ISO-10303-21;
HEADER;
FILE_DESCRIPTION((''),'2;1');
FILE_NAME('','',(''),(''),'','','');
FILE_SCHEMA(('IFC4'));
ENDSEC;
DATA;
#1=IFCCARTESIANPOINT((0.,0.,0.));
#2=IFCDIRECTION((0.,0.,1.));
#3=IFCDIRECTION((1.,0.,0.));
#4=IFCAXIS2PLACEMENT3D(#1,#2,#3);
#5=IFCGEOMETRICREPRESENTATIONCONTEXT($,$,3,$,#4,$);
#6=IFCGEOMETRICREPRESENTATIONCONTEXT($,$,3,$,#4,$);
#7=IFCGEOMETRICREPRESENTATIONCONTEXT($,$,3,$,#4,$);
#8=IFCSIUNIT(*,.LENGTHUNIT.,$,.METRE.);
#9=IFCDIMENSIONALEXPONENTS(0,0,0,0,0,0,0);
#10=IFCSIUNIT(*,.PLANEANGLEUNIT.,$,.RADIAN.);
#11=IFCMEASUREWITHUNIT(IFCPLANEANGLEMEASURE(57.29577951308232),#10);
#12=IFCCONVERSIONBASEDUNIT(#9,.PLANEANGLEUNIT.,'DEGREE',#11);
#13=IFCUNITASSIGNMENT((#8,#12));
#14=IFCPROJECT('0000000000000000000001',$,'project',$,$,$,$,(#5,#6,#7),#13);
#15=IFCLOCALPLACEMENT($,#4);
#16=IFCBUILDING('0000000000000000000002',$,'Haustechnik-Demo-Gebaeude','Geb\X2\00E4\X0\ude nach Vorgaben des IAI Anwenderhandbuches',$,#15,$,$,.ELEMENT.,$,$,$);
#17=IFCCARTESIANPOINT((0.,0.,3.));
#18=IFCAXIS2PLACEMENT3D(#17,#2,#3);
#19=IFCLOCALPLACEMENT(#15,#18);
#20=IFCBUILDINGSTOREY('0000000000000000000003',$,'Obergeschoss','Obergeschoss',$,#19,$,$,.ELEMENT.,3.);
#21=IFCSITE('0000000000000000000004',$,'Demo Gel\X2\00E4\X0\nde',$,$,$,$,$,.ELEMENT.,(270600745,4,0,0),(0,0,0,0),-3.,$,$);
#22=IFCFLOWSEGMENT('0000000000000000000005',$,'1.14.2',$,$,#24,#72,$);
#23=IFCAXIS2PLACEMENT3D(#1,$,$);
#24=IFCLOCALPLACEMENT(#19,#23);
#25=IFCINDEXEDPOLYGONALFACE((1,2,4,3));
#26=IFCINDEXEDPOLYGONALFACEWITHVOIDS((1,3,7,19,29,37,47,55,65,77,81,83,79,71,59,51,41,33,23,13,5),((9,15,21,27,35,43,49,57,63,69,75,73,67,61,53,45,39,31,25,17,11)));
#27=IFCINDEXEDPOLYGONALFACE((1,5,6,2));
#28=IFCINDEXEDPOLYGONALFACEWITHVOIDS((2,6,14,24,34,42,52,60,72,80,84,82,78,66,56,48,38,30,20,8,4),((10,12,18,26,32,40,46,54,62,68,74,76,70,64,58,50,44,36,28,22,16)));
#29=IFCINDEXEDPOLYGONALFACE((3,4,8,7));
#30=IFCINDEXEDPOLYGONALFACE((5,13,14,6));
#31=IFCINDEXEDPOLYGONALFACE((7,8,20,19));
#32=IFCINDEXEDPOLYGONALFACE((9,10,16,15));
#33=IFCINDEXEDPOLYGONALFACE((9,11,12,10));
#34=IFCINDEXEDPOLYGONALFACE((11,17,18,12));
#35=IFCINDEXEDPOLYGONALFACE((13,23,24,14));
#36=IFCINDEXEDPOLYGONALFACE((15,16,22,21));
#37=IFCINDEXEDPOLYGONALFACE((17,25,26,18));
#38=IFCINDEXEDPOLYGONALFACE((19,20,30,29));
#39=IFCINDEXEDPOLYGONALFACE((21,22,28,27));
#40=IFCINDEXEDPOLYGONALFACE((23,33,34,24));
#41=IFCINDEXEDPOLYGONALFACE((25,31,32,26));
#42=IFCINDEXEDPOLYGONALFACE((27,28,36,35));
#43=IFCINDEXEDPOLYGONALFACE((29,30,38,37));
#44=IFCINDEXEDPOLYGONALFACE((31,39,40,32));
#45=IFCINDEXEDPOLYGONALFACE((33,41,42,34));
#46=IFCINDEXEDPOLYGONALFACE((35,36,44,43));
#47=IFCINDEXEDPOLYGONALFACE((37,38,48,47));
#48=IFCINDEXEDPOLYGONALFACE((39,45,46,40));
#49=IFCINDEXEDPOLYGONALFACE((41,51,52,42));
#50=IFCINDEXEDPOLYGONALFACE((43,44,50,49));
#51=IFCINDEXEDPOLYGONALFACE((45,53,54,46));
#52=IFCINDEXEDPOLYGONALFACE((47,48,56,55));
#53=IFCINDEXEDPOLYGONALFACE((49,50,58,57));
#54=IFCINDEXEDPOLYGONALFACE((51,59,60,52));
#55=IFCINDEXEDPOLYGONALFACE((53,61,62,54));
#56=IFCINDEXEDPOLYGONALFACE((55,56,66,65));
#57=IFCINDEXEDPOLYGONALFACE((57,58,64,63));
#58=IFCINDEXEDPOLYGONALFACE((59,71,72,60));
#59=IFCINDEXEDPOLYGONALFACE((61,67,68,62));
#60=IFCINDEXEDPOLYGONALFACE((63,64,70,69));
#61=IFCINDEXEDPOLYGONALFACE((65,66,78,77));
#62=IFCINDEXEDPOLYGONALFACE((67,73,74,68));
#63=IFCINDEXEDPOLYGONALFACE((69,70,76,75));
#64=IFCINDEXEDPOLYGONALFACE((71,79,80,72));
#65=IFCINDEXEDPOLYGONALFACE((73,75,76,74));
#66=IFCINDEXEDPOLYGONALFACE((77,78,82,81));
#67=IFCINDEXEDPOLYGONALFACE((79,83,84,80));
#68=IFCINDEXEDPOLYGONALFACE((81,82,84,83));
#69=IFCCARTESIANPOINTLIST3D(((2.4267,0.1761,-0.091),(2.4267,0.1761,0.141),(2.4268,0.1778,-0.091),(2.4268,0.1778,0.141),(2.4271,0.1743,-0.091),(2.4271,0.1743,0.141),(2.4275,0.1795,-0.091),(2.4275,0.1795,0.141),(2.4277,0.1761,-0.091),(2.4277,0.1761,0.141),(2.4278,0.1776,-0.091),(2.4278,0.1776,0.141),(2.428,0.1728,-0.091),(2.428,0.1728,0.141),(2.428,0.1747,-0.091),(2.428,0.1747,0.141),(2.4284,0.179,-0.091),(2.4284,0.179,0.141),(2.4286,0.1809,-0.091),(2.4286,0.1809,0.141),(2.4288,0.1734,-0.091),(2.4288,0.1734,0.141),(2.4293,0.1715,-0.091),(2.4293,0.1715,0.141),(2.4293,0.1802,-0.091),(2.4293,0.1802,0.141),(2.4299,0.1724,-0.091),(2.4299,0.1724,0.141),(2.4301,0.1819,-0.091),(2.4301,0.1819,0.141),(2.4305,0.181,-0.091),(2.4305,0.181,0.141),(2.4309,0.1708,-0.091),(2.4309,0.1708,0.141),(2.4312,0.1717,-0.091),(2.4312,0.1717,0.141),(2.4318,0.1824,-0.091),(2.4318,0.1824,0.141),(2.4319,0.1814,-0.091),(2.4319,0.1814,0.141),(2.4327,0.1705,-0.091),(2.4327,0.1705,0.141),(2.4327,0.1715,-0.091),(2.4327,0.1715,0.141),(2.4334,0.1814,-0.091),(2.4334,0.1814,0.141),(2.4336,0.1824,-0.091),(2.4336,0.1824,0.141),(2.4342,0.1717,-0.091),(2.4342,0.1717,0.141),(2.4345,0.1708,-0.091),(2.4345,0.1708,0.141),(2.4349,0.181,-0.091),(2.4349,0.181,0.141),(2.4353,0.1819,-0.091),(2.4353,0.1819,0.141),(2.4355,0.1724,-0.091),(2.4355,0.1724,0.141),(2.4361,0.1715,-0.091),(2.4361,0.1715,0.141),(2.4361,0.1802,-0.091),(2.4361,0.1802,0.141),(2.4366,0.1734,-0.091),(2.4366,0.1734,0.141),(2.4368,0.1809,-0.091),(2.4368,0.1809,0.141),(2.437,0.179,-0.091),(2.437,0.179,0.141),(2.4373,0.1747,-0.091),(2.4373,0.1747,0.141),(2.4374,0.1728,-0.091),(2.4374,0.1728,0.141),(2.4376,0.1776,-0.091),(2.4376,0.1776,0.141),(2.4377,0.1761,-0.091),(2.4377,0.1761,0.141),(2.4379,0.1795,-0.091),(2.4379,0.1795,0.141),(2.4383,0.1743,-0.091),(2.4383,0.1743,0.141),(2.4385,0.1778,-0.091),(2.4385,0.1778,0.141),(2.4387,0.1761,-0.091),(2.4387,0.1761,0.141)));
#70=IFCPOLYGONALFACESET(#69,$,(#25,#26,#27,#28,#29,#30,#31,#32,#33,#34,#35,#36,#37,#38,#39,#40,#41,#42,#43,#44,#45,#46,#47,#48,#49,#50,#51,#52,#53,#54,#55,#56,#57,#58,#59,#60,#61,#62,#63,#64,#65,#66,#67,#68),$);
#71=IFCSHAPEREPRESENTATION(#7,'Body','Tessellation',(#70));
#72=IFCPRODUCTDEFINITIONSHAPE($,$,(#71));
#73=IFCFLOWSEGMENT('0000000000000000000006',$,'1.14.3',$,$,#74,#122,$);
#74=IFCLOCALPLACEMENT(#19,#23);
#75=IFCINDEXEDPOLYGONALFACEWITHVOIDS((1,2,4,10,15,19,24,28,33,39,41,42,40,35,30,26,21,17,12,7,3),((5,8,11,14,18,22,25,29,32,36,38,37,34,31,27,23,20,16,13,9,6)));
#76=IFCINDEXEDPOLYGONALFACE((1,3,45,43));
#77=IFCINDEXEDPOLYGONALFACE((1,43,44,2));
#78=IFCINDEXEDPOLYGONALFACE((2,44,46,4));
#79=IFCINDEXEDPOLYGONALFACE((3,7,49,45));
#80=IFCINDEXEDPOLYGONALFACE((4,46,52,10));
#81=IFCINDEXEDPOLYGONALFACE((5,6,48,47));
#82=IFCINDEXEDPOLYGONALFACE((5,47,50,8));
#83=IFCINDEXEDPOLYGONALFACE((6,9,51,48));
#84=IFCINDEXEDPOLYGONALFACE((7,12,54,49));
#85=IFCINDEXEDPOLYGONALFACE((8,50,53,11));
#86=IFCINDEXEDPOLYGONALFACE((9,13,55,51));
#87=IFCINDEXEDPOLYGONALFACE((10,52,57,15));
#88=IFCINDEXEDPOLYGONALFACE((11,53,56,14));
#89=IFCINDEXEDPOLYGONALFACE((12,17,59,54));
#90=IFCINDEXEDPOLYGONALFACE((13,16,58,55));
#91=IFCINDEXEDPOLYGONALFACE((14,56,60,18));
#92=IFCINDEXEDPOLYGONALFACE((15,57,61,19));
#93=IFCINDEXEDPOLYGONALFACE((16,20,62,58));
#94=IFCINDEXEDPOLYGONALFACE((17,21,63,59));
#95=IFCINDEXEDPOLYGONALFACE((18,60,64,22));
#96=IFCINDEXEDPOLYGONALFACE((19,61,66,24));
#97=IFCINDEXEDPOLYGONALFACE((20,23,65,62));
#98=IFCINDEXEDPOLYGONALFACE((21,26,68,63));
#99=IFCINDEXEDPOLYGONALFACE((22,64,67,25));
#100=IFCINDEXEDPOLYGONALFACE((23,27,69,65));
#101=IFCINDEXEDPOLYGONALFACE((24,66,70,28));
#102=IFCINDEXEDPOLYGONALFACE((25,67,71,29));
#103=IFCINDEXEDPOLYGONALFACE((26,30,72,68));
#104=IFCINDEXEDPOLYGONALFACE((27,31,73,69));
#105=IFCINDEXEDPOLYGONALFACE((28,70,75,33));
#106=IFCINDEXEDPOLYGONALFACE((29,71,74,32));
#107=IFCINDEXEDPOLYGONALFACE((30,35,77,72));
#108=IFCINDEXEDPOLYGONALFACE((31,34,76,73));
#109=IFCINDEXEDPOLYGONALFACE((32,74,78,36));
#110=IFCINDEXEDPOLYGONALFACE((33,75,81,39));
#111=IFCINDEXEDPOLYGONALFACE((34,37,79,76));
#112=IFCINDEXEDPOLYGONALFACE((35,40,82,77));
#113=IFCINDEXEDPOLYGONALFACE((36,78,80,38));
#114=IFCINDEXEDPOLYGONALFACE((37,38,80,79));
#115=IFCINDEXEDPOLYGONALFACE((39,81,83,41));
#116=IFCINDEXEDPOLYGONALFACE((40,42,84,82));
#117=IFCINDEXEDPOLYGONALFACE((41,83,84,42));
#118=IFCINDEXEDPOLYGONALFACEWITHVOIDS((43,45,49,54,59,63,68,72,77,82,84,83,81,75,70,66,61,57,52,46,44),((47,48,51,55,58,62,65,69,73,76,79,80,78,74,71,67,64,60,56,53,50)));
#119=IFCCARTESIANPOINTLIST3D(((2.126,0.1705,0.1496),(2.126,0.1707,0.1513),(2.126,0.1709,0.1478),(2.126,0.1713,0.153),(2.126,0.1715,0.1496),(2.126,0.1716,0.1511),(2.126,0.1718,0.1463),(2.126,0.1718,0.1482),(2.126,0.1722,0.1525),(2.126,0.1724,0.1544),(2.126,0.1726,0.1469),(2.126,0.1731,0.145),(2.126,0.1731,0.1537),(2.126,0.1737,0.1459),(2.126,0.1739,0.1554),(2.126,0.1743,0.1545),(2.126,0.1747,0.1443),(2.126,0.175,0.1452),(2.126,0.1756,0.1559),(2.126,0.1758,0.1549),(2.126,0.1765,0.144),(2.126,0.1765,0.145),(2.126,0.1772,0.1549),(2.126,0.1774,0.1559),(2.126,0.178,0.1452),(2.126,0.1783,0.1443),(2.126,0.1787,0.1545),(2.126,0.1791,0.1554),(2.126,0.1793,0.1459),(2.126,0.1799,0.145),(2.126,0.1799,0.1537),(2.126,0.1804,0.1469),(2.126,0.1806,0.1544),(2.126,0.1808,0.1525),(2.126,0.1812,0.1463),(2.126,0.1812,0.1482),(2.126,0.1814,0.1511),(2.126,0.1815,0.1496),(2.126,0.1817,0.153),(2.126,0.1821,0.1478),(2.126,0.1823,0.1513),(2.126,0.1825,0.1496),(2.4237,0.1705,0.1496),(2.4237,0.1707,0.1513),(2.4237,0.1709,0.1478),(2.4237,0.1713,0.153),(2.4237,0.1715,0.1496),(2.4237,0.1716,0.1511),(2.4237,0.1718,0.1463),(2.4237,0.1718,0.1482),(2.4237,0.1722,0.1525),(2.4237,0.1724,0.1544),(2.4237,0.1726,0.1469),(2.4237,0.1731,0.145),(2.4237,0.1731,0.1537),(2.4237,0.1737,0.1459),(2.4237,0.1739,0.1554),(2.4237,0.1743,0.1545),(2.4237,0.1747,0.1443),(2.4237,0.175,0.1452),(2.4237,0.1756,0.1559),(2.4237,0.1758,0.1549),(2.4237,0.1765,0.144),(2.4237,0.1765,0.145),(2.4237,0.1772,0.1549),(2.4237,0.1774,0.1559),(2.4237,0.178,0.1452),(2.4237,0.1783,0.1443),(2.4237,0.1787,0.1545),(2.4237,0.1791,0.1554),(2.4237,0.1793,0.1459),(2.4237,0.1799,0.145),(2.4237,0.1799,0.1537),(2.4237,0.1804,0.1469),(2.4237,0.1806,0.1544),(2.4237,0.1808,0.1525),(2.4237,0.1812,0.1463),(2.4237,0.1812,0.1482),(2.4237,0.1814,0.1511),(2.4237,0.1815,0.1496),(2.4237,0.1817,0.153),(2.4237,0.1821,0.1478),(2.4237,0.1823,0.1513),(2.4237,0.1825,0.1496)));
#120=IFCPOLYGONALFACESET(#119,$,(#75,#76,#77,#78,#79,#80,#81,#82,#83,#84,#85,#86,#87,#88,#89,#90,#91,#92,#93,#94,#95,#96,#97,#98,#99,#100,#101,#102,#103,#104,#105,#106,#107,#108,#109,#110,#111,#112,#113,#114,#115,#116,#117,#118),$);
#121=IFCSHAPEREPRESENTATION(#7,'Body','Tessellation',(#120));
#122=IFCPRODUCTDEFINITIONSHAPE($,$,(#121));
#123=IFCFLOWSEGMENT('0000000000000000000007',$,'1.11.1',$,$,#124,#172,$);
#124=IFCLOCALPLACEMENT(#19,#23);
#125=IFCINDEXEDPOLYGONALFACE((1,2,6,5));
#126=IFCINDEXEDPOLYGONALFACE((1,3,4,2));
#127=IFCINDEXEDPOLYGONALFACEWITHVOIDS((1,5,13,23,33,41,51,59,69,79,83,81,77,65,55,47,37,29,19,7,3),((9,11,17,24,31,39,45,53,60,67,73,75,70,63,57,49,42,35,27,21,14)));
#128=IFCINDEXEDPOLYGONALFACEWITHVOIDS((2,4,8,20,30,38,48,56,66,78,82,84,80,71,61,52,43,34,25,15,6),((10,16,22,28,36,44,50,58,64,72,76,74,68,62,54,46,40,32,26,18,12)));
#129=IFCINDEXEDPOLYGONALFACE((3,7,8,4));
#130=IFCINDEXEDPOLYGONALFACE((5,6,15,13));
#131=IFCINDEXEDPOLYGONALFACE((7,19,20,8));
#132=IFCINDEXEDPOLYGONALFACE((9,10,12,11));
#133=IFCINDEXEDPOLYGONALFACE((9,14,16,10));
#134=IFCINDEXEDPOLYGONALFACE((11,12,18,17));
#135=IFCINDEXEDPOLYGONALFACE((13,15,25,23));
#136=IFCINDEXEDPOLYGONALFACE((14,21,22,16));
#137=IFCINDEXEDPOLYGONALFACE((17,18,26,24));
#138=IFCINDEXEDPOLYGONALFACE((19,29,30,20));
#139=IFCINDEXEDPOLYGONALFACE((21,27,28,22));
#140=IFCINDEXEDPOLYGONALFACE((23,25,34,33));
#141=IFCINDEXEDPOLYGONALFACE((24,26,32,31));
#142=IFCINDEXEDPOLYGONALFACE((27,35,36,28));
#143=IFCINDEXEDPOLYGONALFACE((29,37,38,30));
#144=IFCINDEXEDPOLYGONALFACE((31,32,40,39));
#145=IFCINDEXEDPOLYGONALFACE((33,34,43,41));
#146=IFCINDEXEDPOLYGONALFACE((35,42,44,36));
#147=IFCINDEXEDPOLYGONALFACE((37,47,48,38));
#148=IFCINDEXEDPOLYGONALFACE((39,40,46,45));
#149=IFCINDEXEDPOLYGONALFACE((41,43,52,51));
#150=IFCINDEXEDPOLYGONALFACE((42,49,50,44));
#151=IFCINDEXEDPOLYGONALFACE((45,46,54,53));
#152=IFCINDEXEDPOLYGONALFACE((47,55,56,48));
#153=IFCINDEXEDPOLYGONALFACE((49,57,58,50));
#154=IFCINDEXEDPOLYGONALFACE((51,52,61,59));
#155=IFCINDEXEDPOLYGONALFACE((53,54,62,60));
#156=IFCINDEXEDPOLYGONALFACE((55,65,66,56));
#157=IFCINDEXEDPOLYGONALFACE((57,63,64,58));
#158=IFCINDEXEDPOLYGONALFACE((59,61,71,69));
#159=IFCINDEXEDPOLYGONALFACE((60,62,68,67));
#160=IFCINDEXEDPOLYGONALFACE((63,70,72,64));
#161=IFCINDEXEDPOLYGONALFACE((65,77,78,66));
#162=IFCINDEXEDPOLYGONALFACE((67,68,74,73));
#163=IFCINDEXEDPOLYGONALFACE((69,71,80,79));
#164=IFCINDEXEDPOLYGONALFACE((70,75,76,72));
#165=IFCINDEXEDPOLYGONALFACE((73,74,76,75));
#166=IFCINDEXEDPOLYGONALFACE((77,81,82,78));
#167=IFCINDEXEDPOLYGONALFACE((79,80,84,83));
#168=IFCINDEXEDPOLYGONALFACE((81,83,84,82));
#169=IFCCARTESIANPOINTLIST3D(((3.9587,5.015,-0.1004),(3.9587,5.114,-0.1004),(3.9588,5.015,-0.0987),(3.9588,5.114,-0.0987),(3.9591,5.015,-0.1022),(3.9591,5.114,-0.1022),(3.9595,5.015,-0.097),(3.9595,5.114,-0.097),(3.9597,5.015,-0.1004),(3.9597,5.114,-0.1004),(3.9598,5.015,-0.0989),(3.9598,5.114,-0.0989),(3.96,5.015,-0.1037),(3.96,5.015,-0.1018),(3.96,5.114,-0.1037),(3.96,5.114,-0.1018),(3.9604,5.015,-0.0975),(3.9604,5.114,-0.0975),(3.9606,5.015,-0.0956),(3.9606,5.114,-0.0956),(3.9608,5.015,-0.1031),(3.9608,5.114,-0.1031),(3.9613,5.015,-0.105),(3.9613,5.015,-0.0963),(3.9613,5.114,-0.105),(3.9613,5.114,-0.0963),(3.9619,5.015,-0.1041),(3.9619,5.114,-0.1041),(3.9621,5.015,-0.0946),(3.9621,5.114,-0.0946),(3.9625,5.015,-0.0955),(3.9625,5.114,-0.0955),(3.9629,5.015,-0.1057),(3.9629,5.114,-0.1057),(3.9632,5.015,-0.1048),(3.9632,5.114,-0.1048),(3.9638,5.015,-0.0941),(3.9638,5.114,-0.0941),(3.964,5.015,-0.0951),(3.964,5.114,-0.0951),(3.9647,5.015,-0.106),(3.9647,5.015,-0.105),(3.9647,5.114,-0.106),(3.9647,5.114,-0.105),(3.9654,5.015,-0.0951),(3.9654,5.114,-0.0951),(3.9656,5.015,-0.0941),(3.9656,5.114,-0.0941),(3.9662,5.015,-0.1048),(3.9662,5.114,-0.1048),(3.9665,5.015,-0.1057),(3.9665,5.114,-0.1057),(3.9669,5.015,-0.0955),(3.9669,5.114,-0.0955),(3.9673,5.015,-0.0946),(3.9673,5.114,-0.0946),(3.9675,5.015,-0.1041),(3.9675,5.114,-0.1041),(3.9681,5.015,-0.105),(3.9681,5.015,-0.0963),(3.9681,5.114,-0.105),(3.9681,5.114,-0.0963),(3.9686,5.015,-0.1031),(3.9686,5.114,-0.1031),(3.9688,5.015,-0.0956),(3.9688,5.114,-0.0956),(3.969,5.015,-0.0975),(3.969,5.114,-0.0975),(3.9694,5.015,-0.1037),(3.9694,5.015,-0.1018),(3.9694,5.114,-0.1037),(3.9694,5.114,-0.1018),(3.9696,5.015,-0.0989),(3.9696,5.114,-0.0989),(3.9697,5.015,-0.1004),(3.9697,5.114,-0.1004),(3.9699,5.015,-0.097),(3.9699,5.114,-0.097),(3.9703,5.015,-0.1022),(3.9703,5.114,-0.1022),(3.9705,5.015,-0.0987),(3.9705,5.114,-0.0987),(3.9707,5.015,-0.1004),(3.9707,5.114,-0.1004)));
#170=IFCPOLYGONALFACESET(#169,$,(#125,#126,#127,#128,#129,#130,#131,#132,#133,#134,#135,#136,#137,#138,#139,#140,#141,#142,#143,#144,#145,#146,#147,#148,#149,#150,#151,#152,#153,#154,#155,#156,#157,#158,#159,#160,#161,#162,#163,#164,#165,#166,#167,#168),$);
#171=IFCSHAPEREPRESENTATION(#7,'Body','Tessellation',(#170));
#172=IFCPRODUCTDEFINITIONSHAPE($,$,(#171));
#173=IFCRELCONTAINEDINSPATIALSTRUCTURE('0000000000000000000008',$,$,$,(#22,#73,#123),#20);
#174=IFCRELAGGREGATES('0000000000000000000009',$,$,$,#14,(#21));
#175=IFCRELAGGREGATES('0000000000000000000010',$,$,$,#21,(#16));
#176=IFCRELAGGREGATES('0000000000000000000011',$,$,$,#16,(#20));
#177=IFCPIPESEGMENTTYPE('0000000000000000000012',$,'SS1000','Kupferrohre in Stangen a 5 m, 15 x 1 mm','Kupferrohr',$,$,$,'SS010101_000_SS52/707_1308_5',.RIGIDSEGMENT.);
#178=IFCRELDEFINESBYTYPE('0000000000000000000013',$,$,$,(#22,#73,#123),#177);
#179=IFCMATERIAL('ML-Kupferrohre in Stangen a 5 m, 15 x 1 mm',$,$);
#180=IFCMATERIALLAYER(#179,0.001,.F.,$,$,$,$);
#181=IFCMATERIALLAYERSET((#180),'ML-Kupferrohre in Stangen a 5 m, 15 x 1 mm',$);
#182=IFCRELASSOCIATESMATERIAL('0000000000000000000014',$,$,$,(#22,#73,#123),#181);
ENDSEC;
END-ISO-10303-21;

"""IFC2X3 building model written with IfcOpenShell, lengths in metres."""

from ifc_helpers import new_model, entity, si_unit, converted_unit, frame, origin_with_axes, origin_2d_with_axis, place, context, project, spatial, hollow_circle, extrude, material, layer, layer_set, layer_usage, type_object, element, save


model = new_model("IFC2X3")

# Units and contexts
context_of_model_1 = context(None, 3, world=origin_with_axes())
context_of_model_2 = context(None, 3, world=origin_with_axes())
context_of_model_3 = context(None, 3, world=origin_with_axes())
ifc_project = project(units=[si_unit("LENGTHUNIT", "METRE"), converted_unit("PLANEANGLEUNIT", "DEGREE", entity("IfcPlaneAngleMeasure", 57.29577951308232), si_unit("PLANEANGLEUNIT", "RADIAN"), dimensions=[0, 0, 0, 0, 0, 0, 0])], contexts=[context_of_model_1, context_of_model_2, context_of_model_3])

# Site, building, storey
site = spatial("IfcSite", under=ifc_project, Name="Demo Gelände", CompositionType="ELEMENT", RefLatitude=(270600745, 4, 0, 0), RefLongitude=(0, 0, 0, 0), RefElevation=-3.0)
building_placement = place(None, origin_with_axes())
building = spatial("IfcBuilding", under=site, at=building_placement, Name="Haustechnik-Demo-Gebaeude", Description="Gebäude nach Vorgaben des IAI Anwenderhandbuches", CompositionType="ELEMENT")
storey_placement = place(building_placement, frame((0.0, 0.0, 3.0), z_axis=(0.0, 0.0, 1.0), x_axis=(1.0, 0.0, 0.0)))
storey = spatial("IfcBuildingStorey", under=building, at=storey_placement, Name="Obergeschoss", Description="Obergeschoss", CompositionType="ELEMENT", Elevation=3.0)

# Flow segments
ifc_material = material(Name="ML-Kupferrohre in Stangen a 5 m, 15 x 1 mm")
ifc_layer = layer(ifc_material, 0.001, ventilated=False)
ifc_layer_set = layer_set([ifc_layer], Name="ML-Kupferrohre in Stangen a 5 m, 15 x 1 mm")
ifc_layer_usage = layer_usage(ifc_layer_set, "AXIS2", "POSITIVE", 0.0)
pipe_segment_type_1 = type_object("IfcPipeSegmentType", Name="SS1000", Description="Kupferrohre in Stangen a 5 m, 15 x 1 mm", ApplicableOccurrence="Kupferrohr", ElementType="SS010101_000_SS52/707_1308_5", PredefinedType="RIGIDSEGMENT")
flow_segment_1_placement = place(storey_placement, frame((2.4327, 0.1765, -0.091), z_axis=(0.0, 0.0, 1.0), x_axis=(0.0, -1.0, 0.0)))
element("IfcFlowSegment", 1, at=flow_segment_1_placement, inside=storey, type_object=pipe_segment_type_1, material=ifc_layer_usage, Name="1.14.2", context=context_of_model_3, shape_type="SweptSolid", body=[
    extrude(hollow_circle(Radius=0.006, WallThickness=0.001, at=origin_2d_with_axis()), origin_with_axes(), (0.0, 0.0, 1.0), 0.232),
])
flow_segment_2_placement = place(storey_placement, frame((2.4237, 0.1765, 0.15), z_axis=(-1.0, 0.0, 0.0), x_axis=(0.0, 0.0, -1.0)))
element("IfcFlowSegment", 2, at=flow_segment_2_placement, inside=storey, type_object=pipe_segment_type_1, material=ifc_layer_usage, Name="1.14.3", context=context_of_model_3, shape_type="SweptSolid", body=[
    extrude(hollow_circle(Radius=0.006, WallThickness=0.001, at=origin_2d_with_axis()), origin_with_axes(), (0.0, 0.0, 1.0), 0.2977),
])
flow_segment_3_placement = place(storey_placement, frame((3.9647, 5.114, -0.1), z_axis=(0.0, -1.0, 0.0), x_axis=(0.0, 0.0, -1.0)))
element("IfcFlowSegment", 3, at=flow_segment_3_placement, inside=storey, type_object=pipe_segment_type_1, material=ifc_layer_usage, Name="1.11.1", context=context_of_model_3, shape_type="SweptSolid", body=[
    extrude(hollow_circle(Radius=0.006, WallThickness=0.001, at=origin_2d_with_axis()), origin_with_axes(), (0.0, 0.0, 1.0), 0.099),
])

save(model, "model.ifc")
